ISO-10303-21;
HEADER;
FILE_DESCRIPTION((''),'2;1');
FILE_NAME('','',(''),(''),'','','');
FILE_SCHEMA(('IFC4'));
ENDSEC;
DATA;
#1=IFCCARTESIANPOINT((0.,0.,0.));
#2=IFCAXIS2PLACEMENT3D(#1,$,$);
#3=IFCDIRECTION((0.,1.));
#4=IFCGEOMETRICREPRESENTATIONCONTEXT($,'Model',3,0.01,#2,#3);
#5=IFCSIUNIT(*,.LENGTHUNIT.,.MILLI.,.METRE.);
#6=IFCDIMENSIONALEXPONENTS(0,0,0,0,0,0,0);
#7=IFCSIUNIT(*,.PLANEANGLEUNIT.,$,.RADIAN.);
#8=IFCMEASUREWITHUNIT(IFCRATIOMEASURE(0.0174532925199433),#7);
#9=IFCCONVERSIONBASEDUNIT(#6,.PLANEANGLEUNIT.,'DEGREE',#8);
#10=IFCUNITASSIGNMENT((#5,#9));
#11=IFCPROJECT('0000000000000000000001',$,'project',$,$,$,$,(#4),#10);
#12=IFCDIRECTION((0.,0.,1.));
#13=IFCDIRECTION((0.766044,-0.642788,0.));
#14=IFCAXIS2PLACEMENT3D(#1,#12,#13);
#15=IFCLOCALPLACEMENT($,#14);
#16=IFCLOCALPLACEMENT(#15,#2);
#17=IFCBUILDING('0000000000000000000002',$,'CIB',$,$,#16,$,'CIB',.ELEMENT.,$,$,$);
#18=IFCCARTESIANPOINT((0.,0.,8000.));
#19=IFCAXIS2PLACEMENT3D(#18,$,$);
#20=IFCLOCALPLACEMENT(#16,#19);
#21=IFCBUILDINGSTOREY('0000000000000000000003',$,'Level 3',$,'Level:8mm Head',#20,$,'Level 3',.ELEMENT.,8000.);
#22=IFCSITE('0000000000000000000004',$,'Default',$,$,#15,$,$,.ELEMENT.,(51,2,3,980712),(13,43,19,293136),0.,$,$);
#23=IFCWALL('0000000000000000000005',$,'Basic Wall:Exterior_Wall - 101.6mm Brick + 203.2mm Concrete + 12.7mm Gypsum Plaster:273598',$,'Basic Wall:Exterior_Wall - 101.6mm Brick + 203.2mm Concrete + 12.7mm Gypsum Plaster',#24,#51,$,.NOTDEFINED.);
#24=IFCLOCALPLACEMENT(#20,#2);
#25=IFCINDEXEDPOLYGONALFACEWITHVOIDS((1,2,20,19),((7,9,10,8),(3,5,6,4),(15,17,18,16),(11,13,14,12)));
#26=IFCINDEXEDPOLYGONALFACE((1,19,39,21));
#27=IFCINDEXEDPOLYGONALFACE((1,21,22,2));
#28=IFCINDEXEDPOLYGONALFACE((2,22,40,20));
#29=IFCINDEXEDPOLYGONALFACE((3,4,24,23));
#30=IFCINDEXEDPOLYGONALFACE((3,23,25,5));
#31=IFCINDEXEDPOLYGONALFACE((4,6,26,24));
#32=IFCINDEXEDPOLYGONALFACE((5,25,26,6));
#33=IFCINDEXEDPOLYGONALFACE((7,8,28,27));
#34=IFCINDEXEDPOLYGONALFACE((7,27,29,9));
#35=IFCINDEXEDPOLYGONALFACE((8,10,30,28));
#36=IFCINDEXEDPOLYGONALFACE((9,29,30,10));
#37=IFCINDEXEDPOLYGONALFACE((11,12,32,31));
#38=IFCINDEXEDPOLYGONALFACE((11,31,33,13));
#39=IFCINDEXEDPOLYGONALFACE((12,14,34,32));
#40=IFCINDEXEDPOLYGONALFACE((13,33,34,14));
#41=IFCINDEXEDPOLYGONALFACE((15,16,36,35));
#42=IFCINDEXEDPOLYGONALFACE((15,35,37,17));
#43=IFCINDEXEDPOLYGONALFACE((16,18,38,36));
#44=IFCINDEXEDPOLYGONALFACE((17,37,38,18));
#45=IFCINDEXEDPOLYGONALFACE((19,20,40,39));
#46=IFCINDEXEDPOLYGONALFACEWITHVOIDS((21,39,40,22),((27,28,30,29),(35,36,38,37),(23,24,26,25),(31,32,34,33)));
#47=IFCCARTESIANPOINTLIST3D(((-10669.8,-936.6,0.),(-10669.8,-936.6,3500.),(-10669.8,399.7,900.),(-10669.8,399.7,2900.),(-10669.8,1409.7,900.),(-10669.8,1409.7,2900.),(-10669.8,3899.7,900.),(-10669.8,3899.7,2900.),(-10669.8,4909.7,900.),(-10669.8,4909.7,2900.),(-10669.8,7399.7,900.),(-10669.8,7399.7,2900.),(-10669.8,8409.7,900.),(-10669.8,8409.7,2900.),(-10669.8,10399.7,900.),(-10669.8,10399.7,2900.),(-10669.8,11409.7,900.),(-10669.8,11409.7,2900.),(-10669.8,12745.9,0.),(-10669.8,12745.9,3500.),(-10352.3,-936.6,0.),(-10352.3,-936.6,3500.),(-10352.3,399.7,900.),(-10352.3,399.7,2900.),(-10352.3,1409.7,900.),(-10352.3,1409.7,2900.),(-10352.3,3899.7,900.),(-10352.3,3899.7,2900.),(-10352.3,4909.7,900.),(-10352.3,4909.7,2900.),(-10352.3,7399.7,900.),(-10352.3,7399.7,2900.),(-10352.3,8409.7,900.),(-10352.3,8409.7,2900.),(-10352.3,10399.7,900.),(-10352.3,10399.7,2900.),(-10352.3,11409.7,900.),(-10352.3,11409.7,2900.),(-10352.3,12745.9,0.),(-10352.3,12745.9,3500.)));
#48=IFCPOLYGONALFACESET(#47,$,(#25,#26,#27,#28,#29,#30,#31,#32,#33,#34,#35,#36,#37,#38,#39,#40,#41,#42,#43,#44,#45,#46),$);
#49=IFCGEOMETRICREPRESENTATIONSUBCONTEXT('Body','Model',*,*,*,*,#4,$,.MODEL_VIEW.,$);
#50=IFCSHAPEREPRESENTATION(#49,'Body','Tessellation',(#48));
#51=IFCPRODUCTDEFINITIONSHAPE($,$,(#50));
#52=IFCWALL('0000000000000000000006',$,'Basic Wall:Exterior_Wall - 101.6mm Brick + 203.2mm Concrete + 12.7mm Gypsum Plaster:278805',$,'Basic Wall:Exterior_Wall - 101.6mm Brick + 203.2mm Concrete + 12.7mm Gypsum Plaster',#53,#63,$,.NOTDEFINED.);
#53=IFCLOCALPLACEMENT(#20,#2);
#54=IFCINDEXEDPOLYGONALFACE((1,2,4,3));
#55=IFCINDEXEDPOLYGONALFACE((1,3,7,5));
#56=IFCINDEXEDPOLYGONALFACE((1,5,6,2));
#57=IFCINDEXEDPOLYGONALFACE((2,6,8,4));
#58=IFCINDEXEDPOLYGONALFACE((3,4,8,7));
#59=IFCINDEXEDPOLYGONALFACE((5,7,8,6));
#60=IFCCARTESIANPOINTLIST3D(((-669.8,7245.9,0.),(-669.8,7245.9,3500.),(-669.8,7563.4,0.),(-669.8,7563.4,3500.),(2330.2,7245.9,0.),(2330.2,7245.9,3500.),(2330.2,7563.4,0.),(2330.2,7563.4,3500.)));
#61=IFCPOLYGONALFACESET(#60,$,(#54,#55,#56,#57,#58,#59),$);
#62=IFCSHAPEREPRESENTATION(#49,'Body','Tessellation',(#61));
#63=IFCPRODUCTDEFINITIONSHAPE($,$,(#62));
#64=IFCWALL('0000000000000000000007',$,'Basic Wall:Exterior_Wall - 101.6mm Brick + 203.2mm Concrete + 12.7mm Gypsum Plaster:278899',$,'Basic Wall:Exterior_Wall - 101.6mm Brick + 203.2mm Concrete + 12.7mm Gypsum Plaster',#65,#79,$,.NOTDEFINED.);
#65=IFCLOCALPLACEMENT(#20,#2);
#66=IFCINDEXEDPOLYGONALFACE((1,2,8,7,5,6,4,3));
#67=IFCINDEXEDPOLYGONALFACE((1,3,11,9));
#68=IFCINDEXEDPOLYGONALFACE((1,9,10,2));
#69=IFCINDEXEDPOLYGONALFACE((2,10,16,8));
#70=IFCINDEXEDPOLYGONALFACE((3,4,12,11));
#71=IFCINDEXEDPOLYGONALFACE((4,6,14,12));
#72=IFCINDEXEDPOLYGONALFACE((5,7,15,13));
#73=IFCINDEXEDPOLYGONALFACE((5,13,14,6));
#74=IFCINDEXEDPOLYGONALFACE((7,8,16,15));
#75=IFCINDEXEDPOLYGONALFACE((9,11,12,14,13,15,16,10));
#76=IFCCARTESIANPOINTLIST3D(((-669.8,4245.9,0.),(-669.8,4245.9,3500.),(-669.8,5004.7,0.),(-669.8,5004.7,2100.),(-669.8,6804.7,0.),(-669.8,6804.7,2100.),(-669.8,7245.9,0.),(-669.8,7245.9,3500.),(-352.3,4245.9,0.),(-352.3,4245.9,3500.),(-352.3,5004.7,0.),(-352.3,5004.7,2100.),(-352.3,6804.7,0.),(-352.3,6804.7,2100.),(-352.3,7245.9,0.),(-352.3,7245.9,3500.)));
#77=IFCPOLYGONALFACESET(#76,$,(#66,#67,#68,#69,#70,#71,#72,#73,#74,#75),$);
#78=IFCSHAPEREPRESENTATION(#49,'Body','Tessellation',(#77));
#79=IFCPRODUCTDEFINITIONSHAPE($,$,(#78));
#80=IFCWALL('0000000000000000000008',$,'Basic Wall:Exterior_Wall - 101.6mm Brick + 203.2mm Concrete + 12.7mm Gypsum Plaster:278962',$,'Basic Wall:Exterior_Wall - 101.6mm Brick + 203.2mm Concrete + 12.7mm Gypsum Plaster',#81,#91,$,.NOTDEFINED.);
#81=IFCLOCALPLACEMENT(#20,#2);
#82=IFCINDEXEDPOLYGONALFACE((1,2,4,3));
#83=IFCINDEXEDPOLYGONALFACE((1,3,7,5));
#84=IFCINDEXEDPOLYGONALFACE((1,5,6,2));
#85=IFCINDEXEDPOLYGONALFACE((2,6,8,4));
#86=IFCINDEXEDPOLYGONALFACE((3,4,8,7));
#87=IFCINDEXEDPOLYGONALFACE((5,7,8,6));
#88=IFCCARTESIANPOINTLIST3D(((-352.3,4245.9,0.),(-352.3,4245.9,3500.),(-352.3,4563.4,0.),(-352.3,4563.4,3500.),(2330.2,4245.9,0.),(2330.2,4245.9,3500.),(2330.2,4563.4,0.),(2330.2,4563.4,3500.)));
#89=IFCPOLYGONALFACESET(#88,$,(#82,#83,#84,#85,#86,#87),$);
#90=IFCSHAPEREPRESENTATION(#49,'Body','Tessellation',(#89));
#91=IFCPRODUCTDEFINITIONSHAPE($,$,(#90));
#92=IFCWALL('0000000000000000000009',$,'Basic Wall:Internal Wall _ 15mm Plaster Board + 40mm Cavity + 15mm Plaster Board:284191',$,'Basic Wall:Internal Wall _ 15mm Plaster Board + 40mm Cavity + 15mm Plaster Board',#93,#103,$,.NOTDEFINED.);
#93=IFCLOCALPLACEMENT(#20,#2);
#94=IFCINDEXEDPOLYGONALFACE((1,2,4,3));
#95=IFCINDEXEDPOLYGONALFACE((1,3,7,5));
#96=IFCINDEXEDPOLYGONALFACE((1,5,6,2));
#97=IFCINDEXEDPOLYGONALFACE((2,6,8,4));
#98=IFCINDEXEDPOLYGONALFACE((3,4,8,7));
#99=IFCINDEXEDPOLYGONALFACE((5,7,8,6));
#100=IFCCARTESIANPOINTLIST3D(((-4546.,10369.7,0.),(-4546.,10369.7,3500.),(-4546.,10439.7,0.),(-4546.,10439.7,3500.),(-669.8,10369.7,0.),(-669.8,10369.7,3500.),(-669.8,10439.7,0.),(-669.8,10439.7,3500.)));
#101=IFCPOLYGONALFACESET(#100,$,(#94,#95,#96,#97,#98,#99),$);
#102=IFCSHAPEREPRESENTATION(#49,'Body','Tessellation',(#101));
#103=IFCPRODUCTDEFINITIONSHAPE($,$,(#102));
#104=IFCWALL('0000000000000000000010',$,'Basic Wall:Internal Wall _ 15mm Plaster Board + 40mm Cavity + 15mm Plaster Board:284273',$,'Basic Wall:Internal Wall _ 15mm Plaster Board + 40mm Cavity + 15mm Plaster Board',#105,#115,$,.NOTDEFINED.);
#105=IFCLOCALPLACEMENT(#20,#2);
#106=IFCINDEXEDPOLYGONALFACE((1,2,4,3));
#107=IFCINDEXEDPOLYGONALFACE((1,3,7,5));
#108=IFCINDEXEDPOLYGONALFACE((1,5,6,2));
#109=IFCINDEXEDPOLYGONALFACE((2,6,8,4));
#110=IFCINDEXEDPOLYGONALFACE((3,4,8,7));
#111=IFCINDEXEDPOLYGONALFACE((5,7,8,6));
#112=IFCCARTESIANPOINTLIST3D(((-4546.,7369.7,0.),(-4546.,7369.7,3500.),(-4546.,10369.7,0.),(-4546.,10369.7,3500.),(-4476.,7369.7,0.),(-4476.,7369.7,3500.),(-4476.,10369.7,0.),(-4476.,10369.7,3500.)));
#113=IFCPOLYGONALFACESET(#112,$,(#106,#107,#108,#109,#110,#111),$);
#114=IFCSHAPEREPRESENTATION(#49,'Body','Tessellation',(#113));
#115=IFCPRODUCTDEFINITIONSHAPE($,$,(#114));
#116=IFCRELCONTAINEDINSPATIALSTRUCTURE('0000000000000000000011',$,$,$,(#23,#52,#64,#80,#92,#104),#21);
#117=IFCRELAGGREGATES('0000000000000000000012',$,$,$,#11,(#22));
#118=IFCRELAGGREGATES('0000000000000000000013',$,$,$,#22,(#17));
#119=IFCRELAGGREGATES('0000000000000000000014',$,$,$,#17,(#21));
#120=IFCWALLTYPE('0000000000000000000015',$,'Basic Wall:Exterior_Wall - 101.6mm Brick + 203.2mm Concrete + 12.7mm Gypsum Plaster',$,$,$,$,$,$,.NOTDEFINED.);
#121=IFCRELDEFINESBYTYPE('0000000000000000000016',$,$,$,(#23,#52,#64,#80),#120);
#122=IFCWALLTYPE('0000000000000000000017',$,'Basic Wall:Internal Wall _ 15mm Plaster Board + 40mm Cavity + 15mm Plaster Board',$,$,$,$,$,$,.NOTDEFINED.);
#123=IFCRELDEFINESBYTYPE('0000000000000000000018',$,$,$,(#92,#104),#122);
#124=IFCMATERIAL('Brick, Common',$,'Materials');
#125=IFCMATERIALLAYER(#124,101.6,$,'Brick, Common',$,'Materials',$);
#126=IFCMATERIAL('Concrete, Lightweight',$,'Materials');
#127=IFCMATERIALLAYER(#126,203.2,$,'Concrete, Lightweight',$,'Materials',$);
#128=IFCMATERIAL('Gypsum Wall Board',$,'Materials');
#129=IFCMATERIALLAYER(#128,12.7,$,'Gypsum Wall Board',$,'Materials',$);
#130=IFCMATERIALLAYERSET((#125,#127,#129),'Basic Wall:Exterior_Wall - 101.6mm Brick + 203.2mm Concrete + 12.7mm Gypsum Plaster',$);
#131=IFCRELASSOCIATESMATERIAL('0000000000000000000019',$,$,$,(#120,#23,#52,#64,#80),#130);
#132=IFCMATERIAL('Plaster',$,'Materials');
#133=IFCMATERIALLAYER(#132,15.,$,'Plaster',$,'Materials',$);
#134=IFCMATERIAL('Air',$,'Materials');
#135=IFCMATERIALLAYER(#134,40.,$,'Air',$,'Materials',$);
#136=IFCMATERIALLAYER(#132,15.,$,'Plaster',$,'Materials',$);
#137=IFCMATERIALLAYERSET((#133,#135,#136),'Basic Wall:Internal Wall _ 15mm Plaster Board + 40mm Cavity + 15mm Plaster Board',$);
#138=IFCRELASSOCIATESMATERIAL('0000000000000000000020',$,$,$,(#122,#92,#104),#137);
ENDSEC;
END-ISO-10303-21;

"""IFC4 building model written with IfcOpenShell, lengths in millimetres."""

from ifc_helpers import new_model, entity, si_unit, converted_unit, direction, frame, frame_2d, origin, place, context, subcontext, project, spatial, rectangle, extrude, material, layer, layer_set, layer_usage, type_object, element, save


model = new_model("IFC4")

# Units and contexts
model_context = context("Model", 3, precision=0.01, world=origin(), true_north=direction((0.0, 1.0)))
body_context = subcontext(model_context, "Body", "Model", "MODEL_VIEW")
ifc_project = project(units=[si_unit("LENGTHUNIT", "METRE", prefix="MILLI"), converted_unit("PLANEANGLEUNIT", "DEGREE", entity("IfcRatioMeasure", 0.0174532925199433), si_unit("PLANEANGLEUNIT", "RADIAN"), dimensions=[0, 0, 0, 0, 0, 0, 0])], contexts=[model_context])

# Site, building, storey
site_placement = place(None, frame((0.0, 0.0, 0.0), z_axis=(0.0, 0.0, 1.0), x_axis=(0.766044, -0.642788, 0.0)))
site = spatial("IfcSite", under=ifc_project, at=site_placement, Name="Default", CompositionType="ELEMENT", RefLatitude=(51, 2, 3, 980712), RefLongitude=(13, 43, 19, 293136), RefElevation=0.0)
building_placement = place(site_placement, origin())
building = spatial("IfcBuilding", under=site, at=building_placement, Name="CIB", LongName="CIB", CompositionType="ELEMENT")
storey_placement = place(building_placement, frame((0.0, 0.0, 8000.0)))
storey = spatial("IfcBuildingStorey", under=building, at=storey_placement, Name="Level 3", ObjectType="Level:8mm Head", LongName="Level 3", CompositionType="ELEMENT", Elevation=8000.0)

# Shared definitions
ifc_material_1 = material(Name="Plaster", Category="Materials")

# Shared definitions
ifc_material_2 = material(Name="Brick, Common", Category="Materials")
ifc_layer_1 = layer(ifc_material_2, 101.6, Name="Brick, Common", Category="Materials")
ifc_material_3 = material(Name="Concrete, Lightweight", Category="Materials")
ifc_layer_2 = layer(ifc_material_3, 203.2, Name="Concrete, Lightweight", Category="Materials")
ifc_material_4 = material(Name="Gypsum Wall Board", Category="Materials")
ifc_layer_3 = layer(ifc_material_4, 12.7, Name="Gypsum Wall Board", Category="Materials")
ifc_layer_set_1 = layer_set([ifc_layer_1, ifc_layer_2, ifc_layer_3], Name="Basic Wall:Exterior_Wall - 101.6mm Brick + 203.2mm Concrete + 12.7mm Gypsum Plaster")
wall_type_1 = type_object("IfcWallType", Name="Basic Wall:Exterior_Wall - 101.6mm Brick + 203.2mm Concrete + 12.7mm Gypsum Plaster", PredefinedType="NOTDEFINED", material=ifc_layer_set_1)

# Wall, openings
ifc_layer_usage_1 = layer_usage(ifc_layer_set_1, "AXIS2", "NEGATIVE", 158.8)
wall_1_placement = place(storey_placement, frame((-10511.0, -936.6, 0.0), z_axis=(0.0, 0.0, 1.0), x_axis=(0.0, 1.0, 0.0)))
wall_1 = element("IfcWall", 1, at=wall_1_placement, inside=storey, type_object=wall_type_1, material=ifc_layer_usage_1, Name="Basic Wall:Exterior_Wall - 101.6mm Brick + 203.2mm Concrete + 12.7mm Gypsum Plaster:273598", ObjectType="Basic Wall:Exterior_Wall - 101.6mm Brick + 203.2mm Concrete + 12.7mm Gypsum Plaster", PredefinedType="NOTDEFINED", context=body_context, shape_type="SweptSolid", body=[
    extrude(rectangle(XDim=13682.5, YDim=317.5, at=frame_2d((6841.2, 0.0), x_axis=(-1.0, 0.0))), origin(), (0.0, 0.0, 1.0), 3500.0),
])
opening_1_placement = place(wall_1_placement, frame((2346.2, 158.8, 900.0)))
element("IfcOpeningElement", 2, at=opening_1_placement, cuts=wall_1, ObjectType="Opening", PredefinedType="OPENING", context=body_context, shape_type="SweptSolid", body=[
    extrude(rectangle(XDim=2000.0, YDim=1010.0, at=frame_2d((1000.0, 505.0), x_axis=(1.0, 0.0))), frame((0.0, 0.0, 0.0), z_axis=(0.0, -1.0, 0.0), x_axis=(0.0, 0.0, 1.0)), (0.0, 0.0, 1.0), 317.5),
])
opening_2_placement = place(wall_1_placement, frame((12346.2, 158.8, 900.0)))
element("IfcOpeningElement", 3, at=opening_2_placement, cuts=wall_1, ObjectType="Opening", PredefinedType="OPENING", context=body_context, shape_type="SweptSolid", body=[
    extrude(rectangle(XDim=2000.0, YDim=1010.0, at=frame_2d((1000.0, 505.0), x_axis=(1.0, 0.0))), frame((0.0, 0.0, 0.0), z_axis=(0.0, -1.0, 0.0), x_axis=(0.0, 0.0, 1.0)), (0.0, 0.0, 1.0), 317.5),
])
opening_3_placement = place(wall_1_placement, frame((9346.2, 158.8, 900.0)))
element("IfcOpeningElement", 4, at=opening_3_placement, cuts=wall_1, ObjectType="Opening", PredefinedType="OPENING", context=body_context, shape_type="SweptSolid", body=[
    extrude(rectangle(XDim=2000.0, YDim=1010.0, at=frame_2d((1000.0, 505.0), x_axis=(1.0, 0.0))), frame((0.0, 0.0, 0.0), z_axis=(0.0, -1.0, 0.0), x_axis=(0.0, 0.0, 1.0)), (0.0, 0.0, 1.0), 317.5),
])
opening_4_placement = place(wall_1_placement, frame((5846.2, 158.8, 900.0)))
element("IfcOpeningElement", 5, at=opening_4_placement, cuts=wall_1, ObjectType="Opening", PredefinedType="OPENING", context=body_context, shape_type="SweptSolid", body=[
    extrude(rectangle(XDim=2000.0, YDim=1010.0, at=frame_2d((1000.0, 505.0), x_axis=(1.0, 0.0))), frame((0.0, 0.0, 0.0), z_axis=(0.0, -1.0, 0.0), x_axis=(0.0, 0.0, 1.0)), (0.0, 0.0, 1.0), 317.5),
])

# Wall
ifc_layer_usage_2 = layer_usage(ifc_layer_set_1, "AXIS2", "NEGATIVE", 158.8)
wall_2_placement = place(storey_placement, frame((2330.2, 7404.7, 0.0), z_axis=(0.0, 0.0, 1.0), x_axis=(-1.0, 0.0, 0.0)))
element("IfcWall", 6, at=wall_2_placement, inside=storey, type_object=wall_type_1, material=ifc_layer_usage_2, Name="Basic Wall:Exterior_Wall - 101.6mm Brick + 203.2mm Concrete + 12.7mm Gypsum Plaster:278805", ObjectType="Basic Wall:Exterior_Wall - 101.6mm Brick + 203.2mm Concrete + 12.7mm Gypsum Plaster", PredefinedType="NOTDEFINED", context=body_context, shape_type="SweptSolid", body=[
    extrude(rectangle(XDim=3000.0, YDim=317.5, at=frame_2d((1500.0, 0.0), x_axis=(-1.0, 0.0))), origin(), (0.0, 0.0, 1.0), 3500.0),
])

# Wall, opening
ifc_layer_usage_3 = layer_usage(ifc_layer_set_1, "AXIS2", "NEGATIVE", 158.8)
wall_3_placement = place(storey_placement, frame((-511.0, 7245.9, 0.0), z_axis=(0.0, 0.0, 1.0), x_axis=(0.0, -1.0, 0.0)))
wall_3 = element("IfcWall", 7, at=wall_3_placement, inside=storey, type_object=wall_type_1, material=ifc_layer_usage_3, Name="Basic Wall:Exterior_Wall - 101.6mm Brick + 203.2mm Concrete + 12.7mm Gypsum Plaster:278899", ObjectType="Basic Wall:Exterior_Wall - 101.6mm Brick + 203.2mm Concrete + 12.7mm Gypsum Plaster", PredefinedType="NOTDEFINED", context=body_context, shape_type="SweptSolid", body=[
    extrude(rectangle(XDim=3000.0, YDim=317.5, at=frame_2d((1500.0, 0.0), x_axis=(-1.0, 0.0))), origin(), (0.0, 0.0, 1.0), 3500.0),
])
opening_5_placement = place(wall_3_placement, frame((2241.3, 158.7, 0.0)))
element("IfcOpeningElement", 8, at=opening_5_placement, cuts=wall_3, ObjectType="Opening", PredefinedType="OPENING", context=body_context, shape_type="SweptSolid", body=[
    extrude(rectangle(XDim=2100.0, YDim=1800.0, at=frame_2d((1050.0, 900.0), x_axis=(1.0, 0.0))), frame((0.0, 0.0, 0.0), z_axis=(0.0, -1.0, 0.0), x_axis=(0.0, 0.0, 1.0)), (0.0, 0.0, 1.0), 317.5),
])

# Walls
ifc_layer_usage_4 = layer_usage(ifc_layer_set_1, "AXIS2", "NEGATIVE", 158.8)
wall_4_placement = place(storey_placement, frame((-352.3, 4404.7, 0.0)))
element("IfcWall", 9, at=wall_4_placement, inside=storey, type_object=wall_type_1, material=ifc_layer_usage_4, Name="Basic Wall:Exterior_Wall - 101.6mm Brick + 203.2mm Concrete + 12.7mm Gypsum Plaster:278962", ObjectType="Basic Wall:Exterior_Wall - 101.6mm Brick + 203.2mm Concrete + 12.7mm Gypsum Plaster", PredefinedType="NOTDEFINED", context=body_context, shape_type="SweptSolid", body=[
    extrude(rectangle(XDim=2682.5, YDim=317.5, at=frame_2d((1341.2, 0.0), x_axis=(-1.0, 0.0))), origin(), (0.0, 0.0, 1.0), 3500.0),
])
ifc_layer_4 = layer(ifc_material_1, 15.0, Name="Plaster", Category="Materials")
ifc_material_5 = material(Name="Air", Category="Materials")
ifc_layer_5 = layer(ifc_material_5, 40.0, Name="Air", Category="Materials")
ifc_layer_6 = layer(ifc_material_1, 15.0, Name="Plaster", Category="Materials")
ifc_layer_set_2 = layer_set([ifc_layer_4, ifc_layer_5, ifc_layer_6], Name="Basic Wall:Internal Wall _ 15mm Plaster Board + 40mm Cavity + 15mm Plaster Board")
ifc_layer_usage_5 = layer_usage(ifc_layer_set_2, "AXIS2", "NEGATIVE", 35.0)
wall_type_2 = type_object("IfcWallType", Name="Basic Wall:Internal Wall _ 15mm Plaster Board + 40mm Cavity + 15mm Plaster Board", PredefinedType="NOTDEFINED", material=ifc_layer_set_2)
wall_5_placement = place(storey_placement, frame((-669.8, 10404.7, 0.0), z_axis=(0.0, 0.0, 1.0), x_axis=(-1.0, 0.0, 0.0)))
element("IfcWall", 10, at=wall_5_placement, inside=storey, type_object=wall_type_2, material=ifc_layer_usage_5, Name="Basic Wall:Internal Wall _ 15mm Plaster Board + 40mm Cavity + 15mm Plaster Board:284191", ObjectType="Basic Wall:Internal Wall _ 15mm Plaster Board + 40mm Cavity + 15mm Plaster Board", PredefinedType="NOTDEFINED", context=body_context, shape_type="SweptSolid", body=[
    extrude(rectangle(XDim=3876.2, YDim=70.0, at=frame_2d((1938.1, 0.0), x_axis=(-1.0, 0.0))), origin(), (0.0, 0.0, 1.0), 3500.0),
])
ifc_layer_usage_6 = layer_usage(ifc_layer_set_2, "AXIS2", "NEGATIVE", 35.0)
wall_6_placement = place(storey_placement, frame((-4511.0, 10369.7, 0.0), z_axis=(0.0, 0.0, 1.0), x_axis=(0.0, -1.0, 0.0)))
element("IfcWall", 11, at=wall_6_placement, inside=storey, type_object=wall_type_2, material=ifc_layer_usage_6, Name="Basic Wall:Internal Wall _ 15mm Plaster Board + 40mm Cavity + 15mm Plaster Board:284273", ObjectType="Basic Wall:Internal Wall _ 15mm Plaster Board + 40mm Cavity + 15mm Plaster Board", PredefinedType="NOTDEFINED", context=body_context, shape_type="SweptSolid", body=[
    extrude(rectangle(XDim=3000.0, YDim=70.0, at=frame_2d((1500.0, 0.0), x_axis=(-1.0, 0.0))), origin(), (0.0, 0.0, 1.0), 3500.0),
])

save(model, "model.ifc")
